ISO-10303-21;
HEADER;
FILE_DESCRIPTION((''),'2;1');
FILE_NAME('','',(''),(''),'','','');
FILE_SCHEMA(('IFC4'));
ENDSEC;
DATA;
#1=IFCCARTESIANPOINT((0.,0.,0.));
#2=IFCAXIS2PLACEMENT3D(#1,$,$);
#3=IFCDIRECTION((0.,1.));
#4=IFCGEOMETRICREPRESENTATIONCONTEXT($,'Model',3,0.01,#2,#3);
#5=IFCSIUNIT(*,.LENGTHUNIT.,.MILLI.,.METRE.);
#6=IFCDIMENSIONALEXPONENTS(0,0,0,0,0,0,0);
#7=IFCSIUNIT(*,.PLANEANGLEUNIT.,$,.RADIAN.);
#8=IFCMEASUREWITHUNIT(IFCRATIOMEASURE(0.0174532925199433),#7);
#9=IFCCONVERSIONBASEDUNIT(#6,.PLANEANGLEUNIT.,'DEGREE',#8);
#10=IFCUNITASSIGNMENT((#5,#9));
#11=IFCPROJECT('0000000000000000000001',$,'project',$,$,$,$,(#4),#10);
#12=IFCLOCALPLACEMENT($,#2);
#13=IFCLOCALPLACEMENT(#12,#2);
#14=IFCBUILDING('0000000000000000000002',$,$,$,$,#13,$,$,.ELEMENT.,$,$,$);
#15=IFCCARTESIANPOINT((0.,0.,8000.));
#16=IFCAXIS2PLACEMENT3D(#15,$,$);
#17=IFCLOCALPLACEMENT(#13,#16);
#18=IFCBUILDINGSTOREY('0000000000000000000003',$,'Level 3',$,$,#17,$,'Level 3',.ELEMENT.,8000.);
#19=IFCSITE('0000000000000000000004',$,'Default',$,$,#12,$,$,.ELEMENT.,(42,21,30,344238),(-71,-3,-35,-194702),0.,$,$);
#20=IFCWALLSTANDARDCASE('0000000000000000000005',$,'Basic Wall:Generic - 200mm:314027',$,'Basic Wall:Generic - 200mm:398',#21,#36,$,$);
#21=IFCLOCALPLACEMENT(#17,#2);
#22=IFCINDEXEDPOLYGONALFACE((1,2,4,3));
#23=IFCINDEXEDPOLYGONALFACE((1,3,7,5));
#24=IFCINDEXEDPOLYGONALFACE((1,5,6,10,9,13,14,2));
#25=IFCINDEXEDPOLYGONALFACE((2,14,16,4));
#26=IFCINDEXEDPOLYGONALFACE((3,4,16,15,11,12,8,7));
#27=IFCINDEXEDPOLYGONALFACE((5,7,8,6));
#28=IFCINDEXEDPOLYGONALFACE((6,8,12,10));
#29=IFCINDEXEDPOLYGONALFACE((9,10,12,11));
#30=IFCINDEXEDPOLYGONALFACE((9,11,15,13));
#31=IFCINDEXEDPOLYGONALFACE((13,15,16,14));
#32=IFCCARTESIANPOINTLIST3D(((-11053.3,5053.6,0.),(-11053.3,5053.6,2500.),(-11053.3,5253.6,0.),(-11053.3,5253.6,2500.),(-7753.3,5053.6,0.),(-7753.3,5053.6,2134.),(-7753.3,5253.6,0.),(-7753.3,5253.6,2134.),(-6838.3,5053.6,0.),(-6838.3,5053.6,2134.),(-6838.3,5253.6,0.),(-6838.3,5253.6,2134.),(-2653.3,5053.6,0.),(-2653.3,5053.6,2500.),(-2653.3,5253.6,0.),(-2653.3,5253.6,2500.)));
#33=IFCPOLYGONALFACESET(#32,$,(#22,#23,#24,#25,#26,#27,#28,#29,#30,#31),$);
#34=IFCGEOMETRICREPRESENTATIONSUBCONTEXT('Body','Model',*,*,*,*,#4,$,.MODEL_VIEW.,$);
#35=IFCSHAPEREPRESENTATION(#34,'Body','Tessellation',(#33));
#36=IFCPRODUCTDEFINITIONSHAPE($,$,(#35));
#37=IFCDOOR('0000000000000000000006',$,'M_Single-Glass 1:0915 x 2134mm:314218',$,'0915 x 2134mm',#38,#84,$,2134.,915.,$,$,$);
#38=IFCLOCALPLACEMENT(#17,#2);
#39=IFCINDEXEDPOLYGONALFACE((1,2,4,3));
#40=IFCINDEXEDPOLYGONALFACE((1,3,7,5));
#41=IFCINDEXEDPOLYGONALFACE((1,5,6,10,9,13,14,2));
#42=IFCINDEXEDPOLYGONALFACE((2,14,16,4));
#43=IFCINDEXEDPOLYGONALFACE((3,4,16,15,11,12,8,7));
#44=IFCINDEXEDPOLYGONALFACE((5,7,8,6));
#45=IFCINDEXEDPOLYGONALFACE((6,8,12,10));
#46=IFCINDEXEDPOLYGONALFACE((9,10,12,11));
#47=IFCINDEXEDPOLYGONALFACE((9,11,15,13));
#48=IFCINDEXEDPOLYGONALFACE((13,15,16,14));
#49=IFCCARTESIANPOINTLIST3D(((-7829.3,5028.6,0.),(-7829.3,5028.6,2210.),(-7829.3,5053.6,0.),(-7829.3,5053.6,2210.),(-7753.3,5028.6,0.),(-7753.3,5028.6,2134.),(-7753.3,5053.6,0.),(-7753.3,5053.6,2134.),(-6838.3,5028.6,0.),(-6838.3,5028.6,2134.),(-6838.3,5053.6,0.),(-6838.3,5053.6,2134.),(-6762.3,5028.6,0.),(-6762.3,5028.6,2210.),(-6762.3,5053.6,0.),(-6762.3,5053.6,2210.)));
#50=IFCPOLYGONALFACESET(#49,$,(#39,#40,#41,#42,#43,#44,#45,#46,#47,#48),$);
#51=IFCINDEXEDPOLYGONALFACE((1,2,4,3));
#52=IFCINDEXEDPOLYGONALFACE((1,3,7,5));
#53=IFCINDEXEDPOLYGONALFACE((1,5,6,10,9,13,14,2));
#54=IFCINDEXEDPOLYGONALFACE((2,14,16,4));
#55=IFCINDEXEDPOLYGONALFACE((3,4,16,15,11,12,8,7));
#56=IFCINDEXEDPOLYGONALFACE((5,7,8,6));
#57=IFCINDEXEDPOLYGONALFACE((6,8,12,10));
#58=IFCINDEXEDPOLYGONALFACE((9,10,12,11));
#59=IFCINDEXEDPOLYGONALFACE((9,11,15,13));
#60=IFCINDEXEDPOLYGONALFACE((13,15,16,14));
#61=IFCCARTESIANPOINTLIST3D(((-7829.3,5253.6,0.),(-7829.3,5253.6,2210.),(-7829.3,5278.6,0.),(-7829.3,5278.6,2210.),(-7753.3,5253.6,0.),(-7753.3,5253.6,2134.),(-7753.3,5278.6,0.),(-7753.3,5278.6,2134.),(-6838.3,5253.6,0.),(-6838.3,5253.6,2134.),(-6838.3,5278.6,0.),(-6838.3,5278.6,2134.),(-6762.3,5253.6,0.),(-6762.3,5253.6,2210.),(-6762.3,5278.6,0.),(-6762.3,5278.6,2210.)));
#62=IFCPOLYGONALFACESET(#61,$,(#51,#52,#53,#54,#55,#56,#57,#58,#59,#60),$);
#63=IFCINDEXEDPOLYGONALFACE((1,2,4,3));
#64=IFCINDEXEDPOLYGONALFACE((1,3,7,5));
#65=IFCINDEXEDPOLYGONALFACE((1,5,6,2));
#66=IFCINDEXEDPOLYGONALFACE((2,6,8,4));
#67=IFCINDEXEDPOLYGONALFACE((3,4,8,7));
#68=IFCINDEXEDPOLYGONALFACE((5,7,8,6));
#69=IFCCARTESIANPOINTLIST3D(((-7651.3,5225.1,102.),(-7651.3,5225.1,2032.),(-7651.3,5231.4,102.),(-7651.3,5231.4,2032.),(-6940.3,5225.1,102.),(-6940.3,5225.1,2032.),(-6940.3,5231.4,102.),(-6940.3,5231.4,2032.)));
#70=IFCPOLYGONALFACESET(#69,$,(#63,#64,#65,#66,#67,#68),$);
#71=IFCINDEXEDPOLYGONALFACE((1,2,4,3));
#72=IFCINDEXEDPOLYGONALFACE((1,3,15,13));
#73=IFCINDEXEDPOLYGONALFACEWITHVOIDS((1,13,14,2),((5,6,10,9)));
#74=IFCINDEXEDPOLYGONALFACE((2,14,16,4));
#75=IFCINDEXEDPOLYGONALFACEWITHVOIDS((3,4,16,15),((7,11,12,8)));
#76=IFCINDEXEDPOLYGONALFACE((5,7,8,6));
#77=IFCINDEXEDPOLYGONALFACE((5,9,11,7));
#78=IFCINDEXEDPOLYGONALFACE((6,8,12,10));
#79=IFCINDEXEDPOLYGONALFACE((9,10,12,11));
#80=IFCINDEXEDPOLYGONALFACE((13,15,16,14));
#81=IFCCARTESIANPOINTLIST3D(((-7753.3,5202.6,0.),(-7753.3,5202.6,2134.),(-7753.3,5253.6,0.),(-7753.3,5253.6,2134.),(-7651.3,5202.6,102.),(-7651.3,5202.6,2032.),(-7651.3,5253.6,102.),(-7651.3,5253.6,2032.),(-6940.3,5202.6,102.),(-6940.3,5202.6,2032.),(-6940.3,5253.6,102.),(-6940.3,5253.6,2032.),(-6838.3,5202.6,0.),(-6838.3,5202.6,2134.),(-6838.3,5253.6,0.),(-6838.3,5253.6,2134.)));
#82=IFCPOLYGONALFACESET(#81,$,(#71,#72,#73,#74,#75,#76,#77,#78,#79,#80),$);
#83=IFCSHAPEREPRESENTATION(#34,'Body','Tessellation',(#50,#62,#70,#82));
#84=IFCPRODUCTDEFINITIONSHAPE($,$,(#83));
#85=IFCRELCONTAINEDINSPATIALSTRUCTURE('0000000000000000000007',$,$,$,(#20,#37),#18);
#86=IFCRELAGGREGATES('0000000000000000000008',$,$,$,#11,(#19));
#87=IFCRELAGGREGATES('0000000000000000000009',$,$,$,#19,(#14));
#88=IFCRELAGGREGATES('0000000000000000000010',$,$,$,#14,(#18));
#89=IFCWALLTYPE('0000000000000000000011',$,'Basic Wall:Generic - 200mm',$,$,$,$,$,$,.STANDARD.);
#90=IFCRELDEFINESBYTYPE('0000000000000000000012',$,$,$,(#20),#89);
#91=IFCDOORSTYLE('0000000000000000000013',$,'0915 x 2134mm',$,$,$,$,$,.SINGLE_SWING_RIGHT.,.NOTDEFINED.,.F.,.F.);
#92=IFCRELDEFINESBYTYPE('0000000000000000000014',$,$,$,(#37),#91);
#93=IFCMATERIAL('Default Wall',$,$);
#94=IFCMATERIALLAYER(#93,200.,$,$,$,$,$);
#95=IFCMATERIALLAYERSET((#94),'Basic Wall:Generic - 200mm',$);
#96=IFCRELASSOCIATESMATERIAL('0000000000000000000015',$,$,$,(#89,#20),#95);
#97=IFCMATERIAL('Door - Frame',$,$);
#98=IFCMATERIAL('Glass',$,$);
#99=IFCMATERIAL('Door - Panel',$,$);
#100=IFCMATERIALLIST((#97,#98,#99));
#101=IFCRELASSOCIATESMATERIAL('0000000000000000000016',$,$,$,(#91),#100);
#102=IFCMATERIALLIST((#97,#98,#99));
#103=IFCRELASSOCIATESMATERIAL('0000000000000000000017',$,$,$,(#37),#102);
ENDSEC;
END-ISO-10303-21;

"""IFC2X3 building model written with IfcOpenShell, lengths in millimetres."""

from ifc_helpers import new_model, entity, si_unit, converted_unit, direction, frame, frame_2d, origin, place, context, subcontext, project, spatial, polyline, rectangle, outline, extrude, source, transform, mapped, material, material_list, layer, layer_set, layer_usage, type_object, type_shapes, element, fill, save


model = new_model("IFC2X3")

# Units and contexts
model_context = context("Model", 3, precision=0.01, world=origin(), true_north=direction((0.0, 1.0)))
body_context = subcontext(model_context, "Body", "Model", "MODEL_VIEW")
ifc_project = project(units=[si_unit("LENGTHUNIT", "METRE", prefix="MILLI"), converted_unit("PLANEANGLEUNIT", "DEGREE", entity("IfcRatioMeasure", 0.0174532925199433), si_unit("PLANEANGLEUNIT", "RADIAN"), dimensions=[0, 0, 0, 0, 0, 0, 0])], contexts=[model_context])

# Site, building, storey
site_placement = place(None, origin())
site = spatial("IfcSite", under=ifc_project, at=site_placement, Name="Default", CompositionType="ELEMENT", RefLatitude=(42, 21, 30, 344238), RefLongitude=(-71, -3, -35, -194702), RefElevation=0.0)
building_placement = place(site_placement, origin())
building = spatial("IfcBuilding", under=site, at=building_placement, CompositionType="ELEMENT")
storey_placement = place(building_placement, frame((0.0, 0.0, 8000.0)))
storey = spatial("IfcBuildingStorey", under=building, at=storey_placement, Name="Level 3", LongName="Level 3", CompositionType="ELEMENT", Elevation=8000.0)

# Shared definitions
ifc_material_1 = material(Name="Default Wall")
ifc_layer = layer(ifc_material_1, 200.0)
ifc_layer_set = layer_set([ifc_layer], Name="Basic Wall:Generic - 200mm")
wall_type = type_object("IfcWallType", Name="Basic Wall:Generic - 200mm", PredefinedType="STANDARD", material=ifc_layer_set)

# Wall, opening, door
ifc_layer_usage_1 = layer_usage(ifc_layer_set, "AXIS2", "NEGATIVE", 100.0)
wall_1_placement = place(storey_placement, frame((-2653.3, 5153.6, 0.0), z_axis=(0.0, 0.0, 1.0), x_axis=(-1.0, 0.0, 0.0)))
wall_1 = element("IfcWallStandardCase", 1, at=wall_1_placement, inside=storey, type_object=wall_type, material=ifc_layer_usage_1, Name="Basic Wall:Generic - 200mm:314027", ObjectType="Basic Wall:Generic - 200mm:398", context=body_context, shape_type="SweptSolid", body=[
    extrude(rectangle(XDim=8400.0, YDim=200.0, at=frame_2d((4200.0, 0.0), x_axis=(-1.0, 0.0))), origin(), (0.0, 0.0, 1.0), 2500.0),
])
opening_placement = place(wall_1_placement, frame((5100.0, 100.0, 0.0)))
opening = element("IfcOpeningElement", 2, at=opening_placement, cuts=wall_1, ObjectType="Opening", context=body_context, shape_type="SweptSolid", body=[
    extrude(rectangle(XDim=915.0, YDim=2134.0, at=frame_2d((1067.0, 457.5), x_axis=(0.0, 1.0))), frame((0.0, 0.0, 0.0), z_axis=(0.0, -1.0, 0.0), x_axis=(0.0, 0.0, 1.0)), (0.0, 0.0, 1.0), 200.0),
])
ifc_material_2 = material(Name="Door - Frame")
ifc_material_3 = material(Name="Glass")
ifc_material_4 = material(Name="Door - Panel")
ifc_material_list_1 = material_list([ifc_material_2, ifc_material_3, ifc_material_4])
ifc_material_list_2 = material_list([ifc_material_2, ifc_material_3, ifc_material_4])
door_style = type_object("IfcDoorStyle", Name="0915 x 2134mm", ConstructionType="NOTDEFINED", OperationType="SINGLE_SWING_RIGHT", ParameterTakesPrecedence=False, Sizeable=False, material=ifc_material_list_2)
shared_shape = source(origin(), body_context, "Body", "SweptSolid", [
    extrude(outline(polyline([(-457.5, -1048.0), (-457.5, 1086.0), (-533.5, 1086.0), (-533.5, -1124.0), (533.5, -1124.0), (533.5, 1086.0), (457.5, 1086.0), (457.5, -1048.0), (-457.5, -1048.0)])), frame((457.5, -25.0, 1086.0), z_axis=(0.0, -1.0, 0.0), x_axis=(-1.0, 0.0, 0.0)), (0.0, 0.0, -1.0), 25.0),
    extrude(outline(polyline([(-457.5, -1048.0), (-457.5, 1086.0), (-533.5, 1086.0), (-533.5, -1124.0), (533.5, -1124.0), (533.5, 1086.0), (457.5, 1086.0), (457.5, -1048.0), (-457.5, -1048.0)])), frame((457.5, 200.0, 1086.0), z_axis=(0.0, -1.0, 0.0), x_axis=(-1.0, 0.0, 0.0)), (0.0, 0.0, -1.0), 25.0),
    extrude(rectangle(XDim=6.3, YDim=711.0, at=frame_2d((0.0, 0.0), x_axis=(1.0, 0.0))), frame((457.5, 174.6, 102.0), z_axis=(0.0, 0.0, 1.0), x_axis=(0.0, 1.0, 0.0)), (0.0, 0.0, 1.0), 1930.0),
    extrude(outline(polyline([(-1067.0, -457.5), (1067.0, -457.5), (1067.0, 457.5), (-1067.0, 457.5), (-1067.0, -457.5)]), holes=[polyline([(-965.0, 355.5), (965.0, 355.5), (965.0, -355.5), (-965.0, -355.5), (-965.0, 355.5)])]), frame((457.5, 149.0, 1067.0), z_axis=(0.0, 1.0, 0.0), x_axis=(0.0, 0.0, -1.0)), (0.0, 0.0, 1.0), 51.0),
])
type_shapes(door_style, [shared_shape])
door_placement = place(opening_placement, frame((0.0, 0.0, 0.0), z_axis=(0.0, 0.0, 1.0), x_axis=(-1.0, 0.0, 0.0)))
door = element("IfcDoor", 3, at=door_placement, inside=storey, type_object=door_style, material=ifc_material_list_1, Name="M_Single-Glass 1:0915 x 2134mm:314218", ObjectType="0915 x 2134mm", OverallHeight=2134.0, OverallWidth=915.0, context=body_context, shape_type="MappedRepresentation", body=[
    mapped(shared_shape, transform((0.0, 0.0, 0.0), scale=1.0)),
])
fill(opening, door)

save(model, "model.ifc")
